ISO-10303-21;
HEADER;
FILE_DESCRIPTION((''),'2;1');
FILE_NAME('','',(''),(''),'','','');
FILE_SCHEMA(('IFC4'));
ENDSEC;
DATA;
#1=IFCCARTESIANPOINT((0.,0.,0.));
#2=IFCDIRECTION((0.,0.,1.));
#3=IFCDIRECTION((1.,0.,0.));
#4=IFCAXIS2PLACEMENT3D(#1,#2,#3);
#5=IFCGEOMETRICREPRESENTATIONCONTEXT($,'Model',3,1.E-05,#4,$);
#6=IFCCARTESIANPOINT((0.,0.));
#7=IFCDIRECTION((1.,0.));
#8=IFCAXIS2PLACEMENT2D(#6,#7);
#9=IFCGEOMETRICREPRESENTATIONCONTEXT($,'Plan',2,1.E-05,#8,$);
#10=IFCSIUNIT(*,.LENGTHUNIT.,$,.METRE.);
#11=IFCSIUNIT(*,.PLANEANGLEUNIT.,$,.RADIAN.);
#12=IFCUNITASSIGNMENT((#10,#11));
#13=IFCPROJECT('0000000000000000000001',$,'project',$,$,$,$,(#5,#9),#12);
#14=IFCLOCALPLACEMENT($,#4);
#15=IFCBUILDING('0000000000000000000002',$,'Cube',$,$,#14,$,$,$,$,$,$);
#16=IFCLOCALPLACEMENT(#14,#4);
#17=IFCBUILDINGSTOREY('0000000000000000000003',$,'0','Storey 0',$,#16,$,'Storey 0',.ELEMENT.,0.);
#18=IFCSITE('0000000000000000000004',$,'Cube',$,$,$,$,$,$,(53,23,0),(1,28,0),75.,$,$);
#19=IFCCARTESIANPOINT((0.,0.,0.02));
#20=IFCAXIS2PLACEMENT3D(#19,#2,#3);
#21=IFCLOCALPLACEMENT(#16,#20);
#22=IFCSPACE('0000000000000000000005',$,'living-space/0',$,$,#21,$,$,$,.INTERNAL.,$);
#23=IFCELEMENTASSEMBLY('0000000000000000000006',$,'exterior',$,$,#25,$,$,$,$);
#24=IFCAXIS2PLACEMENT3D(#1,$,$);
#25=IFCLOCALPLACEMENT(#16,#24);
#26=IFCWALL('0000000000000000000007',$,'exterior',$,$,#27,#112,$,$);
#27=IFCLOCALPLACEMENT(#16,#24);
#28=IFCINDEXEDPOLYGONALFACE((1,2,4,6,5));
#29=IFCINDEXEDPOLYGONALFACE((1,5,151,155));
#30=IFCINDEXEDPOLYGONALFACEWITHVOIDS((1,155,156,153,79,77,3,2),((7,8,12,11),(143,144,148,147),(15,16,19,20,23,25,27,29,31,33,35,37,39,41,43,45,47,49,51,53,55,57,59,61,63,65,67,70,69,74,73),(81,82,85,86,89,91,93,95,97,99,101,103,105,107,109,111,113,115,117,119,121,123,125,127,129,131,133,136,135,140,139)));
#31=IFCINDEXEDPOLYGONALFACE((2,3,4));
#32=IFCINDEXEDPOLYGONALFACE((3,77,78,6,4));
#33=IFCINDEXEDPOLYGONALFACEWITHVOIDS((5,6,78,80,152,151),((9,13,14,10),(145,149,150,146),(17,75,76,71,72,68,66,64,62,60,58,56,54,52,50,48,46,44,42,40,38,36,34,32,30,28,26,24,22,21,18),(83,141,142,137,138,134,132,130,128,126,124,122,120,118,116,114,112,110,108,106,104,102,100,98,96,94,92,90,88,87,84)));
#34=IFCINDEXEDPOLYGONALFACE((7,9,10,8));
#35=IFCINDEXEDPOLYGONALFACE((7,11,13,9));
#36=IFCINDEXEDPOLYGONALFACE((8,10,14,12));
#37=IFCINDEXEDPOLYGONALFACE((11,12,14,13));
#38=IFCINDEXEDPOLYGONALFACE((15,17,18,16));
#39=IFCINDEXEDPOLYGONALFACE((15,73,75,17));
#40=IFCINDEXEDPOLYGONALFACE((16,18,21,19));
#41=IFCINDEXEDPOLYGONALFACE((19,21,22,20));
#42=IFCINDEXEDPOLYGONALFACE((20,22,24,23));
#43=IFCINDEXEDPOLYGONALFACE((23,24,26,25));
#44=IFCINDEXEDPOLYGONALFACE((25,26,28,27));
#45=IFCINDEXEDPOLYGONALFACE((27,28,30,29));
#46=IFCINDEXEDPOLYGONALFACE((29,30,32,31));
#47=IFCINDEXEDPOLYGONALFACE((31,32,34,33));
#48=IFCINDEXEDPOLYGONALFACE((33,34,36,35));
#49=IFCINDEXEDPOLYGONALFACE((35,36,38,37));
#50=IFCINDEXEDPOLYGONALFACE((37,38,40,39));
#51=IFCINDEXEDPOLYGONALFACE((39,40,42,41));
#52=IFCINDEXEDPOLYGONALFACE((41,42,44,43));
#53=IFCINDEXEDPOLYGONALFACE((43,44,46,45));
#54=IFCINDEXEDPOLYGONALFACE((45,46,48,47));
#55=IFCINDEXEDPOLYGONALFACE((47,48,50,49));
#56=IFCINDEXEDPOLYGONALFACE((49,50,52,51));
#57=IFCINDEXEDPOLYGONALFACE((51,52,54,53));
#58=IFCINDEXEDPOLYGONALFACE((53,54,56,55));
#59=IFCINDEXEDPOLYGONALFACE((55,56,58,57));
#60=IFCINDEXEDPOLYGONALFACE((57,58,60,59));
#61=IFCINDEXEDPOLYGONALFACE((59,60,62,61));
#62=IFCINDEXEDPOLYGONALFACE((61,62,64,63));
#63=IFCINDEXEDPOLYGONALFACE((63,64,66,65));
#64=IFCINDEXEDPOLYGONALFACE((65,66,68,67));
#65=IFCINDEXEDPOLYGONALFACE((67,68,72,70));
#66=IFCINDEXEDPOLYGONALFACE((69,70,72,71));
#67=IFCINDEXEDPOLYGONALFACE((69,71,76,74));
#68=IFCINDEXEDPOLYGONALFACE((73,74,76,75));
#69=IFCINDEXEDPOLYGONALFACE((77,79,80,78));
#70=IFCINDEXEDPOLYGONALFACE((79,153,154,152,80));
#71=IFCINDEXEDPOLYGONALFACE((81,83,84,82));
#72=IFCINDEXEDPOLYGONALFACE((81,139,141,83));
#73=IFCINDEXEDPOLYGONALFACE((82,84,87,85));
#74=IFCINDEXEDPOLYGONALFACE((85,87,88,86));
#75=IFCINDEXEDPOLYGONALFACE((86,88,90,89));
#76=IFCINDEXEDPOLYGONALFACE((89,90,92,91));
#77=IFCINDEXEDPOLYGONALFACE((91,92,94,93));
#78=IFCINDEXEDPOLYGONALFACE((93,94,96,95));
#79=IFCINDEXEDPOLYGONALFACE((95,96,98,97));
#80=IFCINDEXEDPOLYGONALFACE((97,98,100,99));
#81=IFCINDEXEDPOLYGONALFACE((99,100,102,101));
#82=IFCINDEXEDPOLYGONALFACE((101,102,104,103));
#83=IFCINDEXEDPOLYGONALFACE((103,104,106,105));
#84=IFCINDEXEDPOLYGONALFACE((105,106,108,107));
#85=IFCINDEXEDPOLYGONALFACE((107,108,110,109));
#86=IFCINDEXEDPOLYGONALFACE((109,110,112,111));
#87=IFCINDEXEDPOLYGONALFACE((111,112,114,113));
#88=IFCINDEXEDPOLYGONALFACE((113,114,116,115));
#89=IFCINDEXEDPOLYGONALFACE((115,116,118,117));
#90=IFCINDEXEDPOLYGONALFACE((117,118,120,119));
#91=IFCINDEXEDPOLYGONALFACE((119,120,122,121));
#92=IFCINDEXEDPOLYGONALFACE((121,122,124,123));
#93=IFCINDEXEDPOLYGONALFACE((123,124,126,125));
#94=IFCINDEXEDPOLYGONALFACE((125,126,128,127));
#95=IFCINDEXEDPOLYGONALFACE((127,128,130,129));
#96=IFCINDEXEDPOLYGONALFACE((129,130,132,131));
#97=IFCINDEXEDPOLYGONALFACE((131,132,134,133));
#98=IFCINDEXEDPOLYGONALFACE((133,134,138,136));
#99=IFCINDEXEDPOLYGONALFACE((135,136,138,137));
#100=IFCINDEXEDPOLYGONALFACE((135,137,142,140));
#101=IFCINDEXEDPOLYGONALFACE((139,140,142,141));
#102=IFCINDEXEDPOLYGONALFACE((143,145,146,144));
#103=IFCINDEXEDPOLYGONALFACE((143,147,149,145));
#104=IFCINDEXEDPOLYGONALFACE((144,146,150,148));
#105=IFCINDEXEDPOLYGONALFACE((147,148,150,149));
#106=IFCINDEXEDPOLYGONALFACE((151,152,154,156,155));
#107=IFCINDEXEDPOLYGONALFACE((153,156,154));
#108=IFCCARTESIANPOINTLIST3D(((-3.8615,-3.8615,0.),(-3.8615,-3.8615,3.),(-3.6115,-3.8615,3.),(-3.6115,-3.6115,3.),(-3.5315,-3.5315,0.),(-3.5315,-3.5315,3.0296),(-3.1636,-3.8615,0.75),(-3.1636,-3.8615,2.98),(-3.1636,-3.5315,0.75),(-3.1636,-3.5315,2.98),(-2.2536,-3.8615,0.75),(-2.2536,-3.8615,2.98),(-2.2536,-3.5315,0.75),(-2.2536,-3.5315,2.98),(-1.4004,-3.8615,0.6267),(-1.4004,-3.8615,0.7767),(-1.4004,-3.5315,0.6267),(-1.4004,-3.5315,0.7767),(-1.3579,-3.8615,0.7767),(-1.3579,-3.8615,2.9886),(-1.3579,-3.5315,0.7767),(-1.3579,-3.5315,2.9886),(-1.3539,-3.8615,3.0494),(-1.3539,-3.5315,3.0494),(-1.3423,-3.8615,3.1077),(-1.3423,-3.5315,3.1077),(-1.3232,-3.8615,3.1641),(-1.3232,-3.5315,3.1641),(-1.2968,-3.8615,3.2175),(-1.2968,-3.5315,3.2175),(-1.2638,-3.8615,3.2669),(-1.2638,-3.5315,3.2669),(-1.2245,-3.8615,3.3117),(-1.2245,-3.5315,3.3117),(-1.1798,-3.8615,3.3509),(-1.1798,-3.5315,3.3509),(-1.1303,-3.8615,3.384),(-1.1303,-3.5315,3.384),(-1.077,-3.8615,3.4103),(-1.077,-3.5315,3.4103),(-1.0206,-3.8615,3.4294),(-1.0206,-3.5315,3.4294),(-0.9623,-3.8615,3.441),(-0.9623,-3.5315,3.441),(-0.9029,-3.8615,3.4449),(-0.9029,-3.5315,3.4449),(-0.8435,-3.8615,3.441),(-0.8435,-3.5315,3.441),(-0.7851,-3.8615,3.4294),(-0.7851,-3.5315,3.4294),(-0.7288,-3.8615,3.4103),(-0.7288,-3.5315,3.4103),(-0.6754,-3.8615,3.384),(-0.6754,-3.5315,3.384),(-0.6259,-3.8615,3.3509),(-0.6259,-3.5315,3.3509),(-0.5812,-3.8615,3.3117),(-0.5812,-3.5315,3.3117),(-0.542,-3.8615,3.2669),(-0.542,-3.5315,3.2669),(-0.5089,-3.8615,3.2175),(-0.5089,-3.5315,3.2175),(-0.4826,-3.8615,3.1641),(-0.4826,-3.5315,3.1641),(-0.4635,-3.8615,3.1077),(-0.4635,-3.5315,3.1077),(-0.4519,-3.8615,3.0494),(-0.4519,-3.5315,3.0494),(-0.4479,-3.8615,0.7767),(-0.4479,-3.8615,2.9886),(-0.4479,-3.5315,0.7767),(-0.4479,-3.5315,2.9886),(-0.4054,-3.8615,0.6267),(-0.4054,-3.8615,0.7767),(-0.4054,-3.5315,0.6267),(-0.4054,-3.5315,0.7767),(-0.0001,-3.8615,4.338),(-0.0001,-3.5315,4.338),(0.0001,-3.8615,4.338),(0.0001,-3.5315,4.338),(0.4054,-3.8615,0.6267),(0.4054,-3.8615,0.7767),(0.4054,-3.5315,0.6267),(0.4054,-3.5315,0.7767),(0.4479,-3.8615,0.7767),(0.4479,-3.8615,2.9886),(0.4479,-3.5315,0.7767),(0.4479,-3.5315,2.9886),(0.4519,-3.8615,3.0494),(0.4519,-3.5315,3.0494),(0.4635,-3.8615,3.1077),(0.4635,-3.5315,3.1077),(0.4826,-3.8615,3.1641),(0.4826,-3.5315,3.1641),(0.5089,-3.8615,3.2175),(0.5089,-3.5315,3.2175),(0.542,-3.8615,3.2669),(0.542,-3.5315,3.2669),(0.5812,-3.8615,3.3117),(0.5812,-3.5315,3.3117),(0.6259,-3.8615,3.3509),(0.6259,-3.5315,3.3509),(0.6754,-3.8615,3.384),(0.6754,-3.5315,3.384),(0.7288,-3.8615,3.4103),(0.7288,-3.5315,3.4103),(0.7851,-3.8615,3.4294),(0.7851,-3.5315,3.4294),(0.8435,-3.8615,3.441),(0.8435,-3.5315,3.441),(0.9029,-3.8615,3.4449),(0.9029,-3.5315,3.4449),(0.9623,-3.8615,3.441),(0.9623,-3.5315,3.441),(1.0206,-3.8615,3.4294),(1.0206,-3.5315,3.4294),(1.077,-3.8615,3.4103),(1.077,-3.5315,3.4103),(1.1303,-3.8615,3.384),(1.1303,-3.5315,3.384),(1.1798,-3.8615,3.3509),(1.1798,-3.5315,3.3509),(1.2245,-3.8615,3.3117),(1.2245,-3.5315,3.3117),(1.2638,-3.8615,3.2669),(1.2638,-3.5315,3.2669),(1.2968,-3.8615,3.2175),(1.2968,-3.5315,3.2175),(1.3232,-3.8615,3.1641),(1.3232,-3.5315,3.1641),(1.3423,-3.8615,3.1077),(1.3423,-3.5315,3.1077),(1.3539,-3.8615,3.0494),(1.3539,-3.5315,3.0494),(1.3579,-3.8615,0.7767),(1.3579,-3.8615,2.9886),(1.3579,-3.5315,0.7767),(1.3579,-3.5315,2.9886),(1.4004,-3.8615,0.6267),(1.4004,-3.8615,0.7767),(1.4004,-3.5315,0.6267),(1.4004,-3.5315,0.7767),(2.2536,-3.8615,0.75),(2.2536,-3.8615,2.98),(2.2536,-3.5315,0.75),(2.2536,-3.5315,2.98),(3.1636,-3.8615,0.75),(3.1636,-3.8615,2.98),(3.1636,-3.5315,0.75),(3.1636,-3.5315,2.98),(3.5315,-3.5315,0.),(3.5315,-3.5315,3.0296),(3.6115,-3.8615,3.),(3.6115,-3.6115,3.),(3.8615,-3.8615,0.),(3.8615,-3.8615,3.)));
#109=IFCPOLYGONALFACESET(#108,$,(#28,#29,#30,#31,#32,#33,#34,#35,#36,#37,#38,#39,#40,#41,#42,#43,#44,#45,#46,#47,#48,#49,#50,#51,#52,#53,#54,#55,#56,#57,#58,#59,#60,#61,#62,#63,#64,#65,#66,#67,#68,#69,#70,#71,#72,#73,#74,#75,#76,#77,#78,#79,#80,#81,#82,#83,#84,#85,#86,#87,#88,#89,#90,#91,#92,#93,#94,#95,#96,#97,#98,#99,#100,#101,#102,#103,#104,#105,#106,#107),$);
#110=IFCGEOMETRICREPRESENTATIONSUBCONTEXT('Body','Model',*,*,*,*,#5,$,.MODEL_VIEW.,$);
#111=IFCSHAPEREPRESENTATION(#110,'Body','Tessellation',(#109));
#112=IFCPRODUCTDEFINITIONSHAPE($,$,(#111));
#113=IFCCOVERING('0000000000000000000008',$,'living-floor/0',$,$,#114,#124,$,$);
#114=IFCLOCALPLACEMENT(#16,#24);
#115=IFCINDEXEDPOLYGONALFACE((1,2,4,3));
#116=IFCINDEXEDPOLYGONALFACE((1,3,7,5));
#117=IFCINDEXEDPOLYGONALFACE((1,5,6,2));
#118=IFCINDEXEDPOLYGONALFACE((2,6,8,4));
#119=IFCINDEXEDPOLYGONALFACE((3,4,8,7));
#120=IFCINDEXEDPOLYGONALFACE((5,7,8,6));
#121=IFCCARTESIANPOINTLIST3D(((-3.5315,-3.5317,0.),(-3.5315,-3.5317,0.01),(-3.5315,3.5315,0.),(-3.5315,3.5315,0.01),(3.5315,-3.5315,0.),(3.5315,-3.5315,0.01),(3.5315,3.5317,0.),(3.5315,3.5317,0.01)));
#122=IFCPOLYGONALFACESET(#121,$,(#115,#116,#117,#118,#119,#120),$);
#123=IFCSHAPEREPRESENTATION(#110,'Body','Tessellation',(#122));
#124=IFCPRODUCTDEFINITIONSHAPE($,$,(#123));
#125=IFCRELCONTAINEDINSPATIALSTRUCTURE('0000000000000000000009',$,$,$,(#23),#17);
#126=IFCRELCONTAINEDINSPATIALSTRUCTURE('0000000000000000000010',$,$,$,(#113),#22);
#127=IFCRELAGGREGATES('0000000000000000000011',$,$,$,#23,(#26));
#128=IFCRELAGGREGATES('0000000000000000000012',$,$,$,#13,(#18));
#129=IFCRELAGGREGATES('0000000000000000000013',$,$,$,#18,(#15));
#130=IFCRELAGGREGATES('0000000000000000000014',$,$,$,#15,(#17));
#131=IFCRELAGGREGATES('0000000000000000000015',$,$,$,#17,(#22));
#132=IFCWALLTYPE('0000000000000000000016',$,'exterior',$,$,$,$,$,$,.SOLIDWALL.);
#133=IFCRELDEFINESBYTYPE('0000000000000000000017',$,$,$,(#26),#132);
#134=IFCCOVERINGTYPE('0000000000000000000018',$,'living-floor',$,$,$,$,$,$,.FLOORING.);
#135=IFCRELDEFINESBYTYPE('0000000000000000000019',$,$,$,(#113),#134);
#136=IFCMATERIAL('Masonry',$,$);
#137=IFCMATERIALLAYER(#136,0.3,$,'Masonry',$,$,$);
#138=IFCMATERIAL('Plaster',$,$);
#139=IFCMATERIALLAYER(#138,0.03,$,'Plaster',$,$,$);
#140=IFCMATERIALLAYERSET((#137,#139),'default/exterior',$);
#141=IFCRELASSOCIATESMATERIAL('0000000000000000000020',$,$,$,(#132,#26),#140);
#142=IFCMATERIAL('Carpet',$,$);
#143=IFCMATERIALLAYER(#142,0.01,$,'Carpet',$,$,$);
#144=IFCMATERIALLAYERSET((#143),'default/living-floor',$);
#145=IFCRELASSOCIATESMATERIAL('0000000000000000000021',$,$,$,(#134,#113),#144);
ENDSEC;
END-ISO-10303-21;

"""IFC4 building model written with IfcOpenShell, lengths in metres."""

from ifc_helpers import new_model, si_unit, frame, origin, origin_with_axes, origin_2d_with_axis, place, context, subcontext, project, spatial, polyline, outline, extrude, clip, bounded_halfspace, material, layer, layer_set, layer_usage, type_object, element, aggregate, save


model = new_model("IFC4")

# Units and contexts
model_context = context("Model", 3, precision=1e-05, world=origin_with_axes())
plan_context = context("Plan", 2, precision=1e-05, world=origin_2d_with_axis())
body_context = subcontext(model_context, "Body", "Model", "MODEL_VIEW")
ifc_project = project(units=[si_unit("LENGTHUNIT", "METRE"), si_unit("PLANEANGLEUNIT", "RADIAN")], contexts=[model_context, plan_context])

# Site, building, storey
site = spatial("IfcSite", under=ifc_project, Name="Cube", RefLatitude=(53, 23, 0), RefLongitude=(1, 28, 0), RefElevation=75.0)
building_placement = place(None, origin_with_axes())
building = spatial("IfcBuilding", under=site, at=building_placement, Name="Cube")
storey_placement = place(building_placement, origin_with_axes())
storey = spatial("IfcBuildingStorey", under=building, at=storey_placement, Name="0", Description="Storey 0", LongName="Storey 0", CompositionType="ELEMENT", Elevation=0.0)

# Element assembly, wall, openings
ifc_material_1 = material(Name="Masonry")
ifc_layer_1 = layer(ifc_material_1, 0.3, Name="Masonry")
ifc_material_2 = material(Name="Plaster")
ifc_layer_2 = layer(ifc_material_2, 0.03, Name="Plaster")
ifc_layer_set_1 = layer_set([ifc_layer_1, ifc_layer_2], Name="default/exterior")
wall_type = type_object("IfcWallType", Name="exterior", PredefinedType="SOLIDWALL", material=ifc_layer_set_1)
assembly_1_placement = place(storey_placement, frame((-3.6115, -3.6115, 0.0), z_axis=(0.0, 0.0, 1.0), x_axis=(1.0, 0.0, 0.0)))
assembly_1 = element("IfcElementAssembly", 1, at=assembly_1_placement, inside=storey, Name="exterior")
ifc_layer_usage_1 = layer_usage(ifc_layer_set_1, "AXIS2", "POSITIVE", -0.25)
wall_1_placement = place(assembly_1_placement, origin_with_axes())
wall_1 = element("IfcWall", 2, at=wall_1_placement, type_object=wall_type, material=ifc_layer_usage_1, Name="exterior", context=body_context, shape_type="Clipping", body=[
    clip(clip(clip(clip(extrude(outline(polyline([(0.08, 0.08), (-0.25, -0.25), (7.473, -0.25), (7.143, 0.08), (0.08, 0.08)])), origin(), (0.0, 0.0, 1.0), 4.338), bounded_halfspace(frame((7.223, 0.0, 3.0), z_axis=(0.347413, 0.0, 0.937712), x_axis=(0.0, -1.0, 0.0)), False, origin(), polyline([(7.223, -1.0), (3.6115, -1.0), (3.6115, 1.0), (7.223, 1.0), (7.223, -1.0)]))), bounded_halfspace(frame((7.223, 0.0, 3.0), z_axis=(0.0, 0.0, 1.0), x_axis=(0.0, 1.0, 0.0)), False, origin(), polyline([(7.223, 1.0), (8.223, 1.0), (8.223, -1.0), (7.223, -1.0), (7.223, 1.0)]))), bounded_halfspace(frame((3.6115, 0.0, 4.338), z_axis=(-0.347413, 0.0, 0.937712), x_axis=(0.0, -1.0, 0.0)), False, origin(), polyline([(3.6115, -1.0), (0.0, -1.0), (0.0, 1.0), (3.6115, 1.0), (3.6115, -1.0)]))), bounded_halfspace(frame((0.0, 0.0, 3.0), z_axis=(0.0, 0.0, 1.0), x_axis=(0.0, -1.0, 0.0)), False, origin(), polyline([(0.0, -1.0), (-1.0, -1.0), (-1.0, 1.0), (0.0, 1.0), (0.0, -1.0)]))),
])
opening_1_placement = place(wall_1_placement, frame((0.4479, -0.25, 0.75), z_axis=(0.0, 0.0, 1.0), x_axis=(1.0, 0.0, 0.0)))
element("IfcOpeningElement", 3, at=opening_1_placement, cuts=wall_1, PredefinedType="OPENING", context=body_context, shape_type="SweptSolid", body=[
    extrude(outline(polyline([(0.0, -0.02), (0.91, -0.02), (0.91, 0.35), (0.0, 0.35), (0.0, -0.02)])), origin(), (0.0, 0.0, 1.0), 2.23),
])
opening_2_placement = place(wall_1_placement, frame((2.2536, -0.25, 0.75), z_axis=(0.0, 0.0, 1.0), x_axis=(1.0, 0.0, 0.0)))
element("IfcOpeningElement", 4, at=opening_2_placement, cuts=wall_1, PredefinedType="OPENING", context=body_context, shape_type="SweptSolid", body=[
    extrude(outline(polyline([(0.1333, 2.5617), (0.1781, 2.6009), (0.2275, 2.634), (0.2809, 2.6603), (0.3373, 2.6794), (0.3956, 2.691), (0.455, 2.6949), (0.5144, 2.691), (0.5727, 2.6794), (0.6291, 2.6603), (0.6825, 2.634), (0.7319, 2.6009), (0.7767, 2.5617), (0.8159, 2.5169), (0.849, 2.4675), (0.8753, 2.4141), (0.8944, 2.3577), (0.906, 2.2994), (0.91, 2.2386), (0.91, 2.2069), (0.91, 0.0267), (0.9525, 0.0267), (0.9525, -0.1233), (-0.0425, -0.1233), (-0.0425, 0.0267), (0.0, 0.0267), (0.0, 2.2069), (0.0, 2.2386), (0.004, 2.2994), (0.0156, 2.3577), (0.0347, 2.4141), (0.061, 2.4675), (0.0941, 2.5169), (0.1333, 2.5617)])), frame((0.0, -0.02, 0.0), z_axis=(0.0, -1.0, 0.0), x_axis=(1.0, 0.0, 0.0)), (0.0, 0.0, -1.0), 0.37),
])
opening_3_placement = place(wall_1_placement, frame((4.0594, -0.25, 0.75), z_axis=(0.0, 0.0, 1.0), x_axis=(1.0, 0.0, 0.0)))
element("IfcOpeningElement", 5, at=opening_3_placement, cuts=wall_1, PredefinedType="OPENING", context=body_context, shape_type="SweptSolid", body=[
    extrude(outline(polyline([(0.1333, 2.5617), (0.1781, 2.6009), (0.2275, 2.634), (0.2809, 2.6603), (0.3373, 2.6794), (0.3956, 2.691), (0.455, 2.6949), (0.5144, 2.691), (0.5727, 2.6794), (0.6291, 2.6603), (0.6825, 2.634), (0.7319, 2.6009), (0.7767, 2.5617), (0.8159, 2.5169), (0.849, 2.4675), (0.8753, 2.4141), (0.8944, 2.3577), (0.906, 2.2994), (0.91, 2.2386), (0.91, 2.2069), (0.91, 0.0267), (0.9525, 0.0267), (0.9525, -0.1233), (-0.0425, -0.1233), (-0.0425, 0.0267), (0.0, 0.0267), (0.0, 2.2069), (0.0, 2.2386), (0.004, 2.2994), (0.0156, 2.3577), (0.0347, 2.4141), (0.061, 2.4675), (0.0941, 2.5169), (0.1333, 2.5617)])), frame((0.0, -0.02, 0.0), z_axis=(0.0, -1.0, 0.0), x_axis=(1.0, 0.0, 0.0)), (0.0, 0.0, -1.0), 0.37),
])
opening_4_placement = place(wall_1_placement, frame((5.8651, -0.25, 0.75), z_axis=(0.0, 0.0, 1.0), x_axis=(1.0, 0.0, 0.0)))
element("IfcOpeningElement", 6, at=opening_4_placement, cuts=wall_1, PredefinedType="OPENING", context=body_context, shape_type="SweptSolid", body=[
    extrude(outline(polyline([(0.0, -0.02), (0.91, -0.02), (0.91, 0.35), (0.0, 0.35), (0.0, -0.02)])), origin(), (0.0, 0.0, 1.0), 2.23),
])
aggregate(assembly_1, [wall_1])

# Shared definitions
space_placement = place(storey_placement, frame((0.0, 0.0, 0.02), z_axis=(0.0, 0.0, 1.0), x_axis=(1.0, 0.0, 0.0)))
space = spatial("IfcSpace", under=storey, at=space_placement, Name="living-space/0", PredefinedType="INTERNAL")

# Covering
ifc_material_3 = material(Name="Carpet")
ifc_layer_3 = layer(ifc_material_3, 0.01, Name="Carpet")
ifc_layer_set_2 = layer_set([ifc_layer_3], Name="default/living-floor")
ifc_layer_usage_2 = layer_usage(ifc_layer_set_2, "AXIS3", "POSITIVE", 0.0)
covering_type = type_object("IfcCoveringType", Name="living-floor", PredefinedType="FLOORING", material=ifc_layer_set_2)
covering_placement = place(space_placement, frame((0.0, 0.0, -0.02), z_axis=(0.0, 0.0, 1.0), x_axis=(1.0, 0.0, 0.0)))
element("IfcCovering", 7, at=covering_placement, inside=space, type_object=covering_type, material=ifc_layer_usage_2, Name="living-floor/0", context=body_context, shape_type="SweptSolid", body=[
    extrude(outline(polyline([(3.5315, -3.5315), (3.5315, 3.5317), (-3.5315, 3.5315), (-3.5315, -3.5317), (3.5315, -3.5315)])), origin_with_axes(), (0.0, 0.0, 1.0), 0.01),
])

save(model, "model.ifc")
